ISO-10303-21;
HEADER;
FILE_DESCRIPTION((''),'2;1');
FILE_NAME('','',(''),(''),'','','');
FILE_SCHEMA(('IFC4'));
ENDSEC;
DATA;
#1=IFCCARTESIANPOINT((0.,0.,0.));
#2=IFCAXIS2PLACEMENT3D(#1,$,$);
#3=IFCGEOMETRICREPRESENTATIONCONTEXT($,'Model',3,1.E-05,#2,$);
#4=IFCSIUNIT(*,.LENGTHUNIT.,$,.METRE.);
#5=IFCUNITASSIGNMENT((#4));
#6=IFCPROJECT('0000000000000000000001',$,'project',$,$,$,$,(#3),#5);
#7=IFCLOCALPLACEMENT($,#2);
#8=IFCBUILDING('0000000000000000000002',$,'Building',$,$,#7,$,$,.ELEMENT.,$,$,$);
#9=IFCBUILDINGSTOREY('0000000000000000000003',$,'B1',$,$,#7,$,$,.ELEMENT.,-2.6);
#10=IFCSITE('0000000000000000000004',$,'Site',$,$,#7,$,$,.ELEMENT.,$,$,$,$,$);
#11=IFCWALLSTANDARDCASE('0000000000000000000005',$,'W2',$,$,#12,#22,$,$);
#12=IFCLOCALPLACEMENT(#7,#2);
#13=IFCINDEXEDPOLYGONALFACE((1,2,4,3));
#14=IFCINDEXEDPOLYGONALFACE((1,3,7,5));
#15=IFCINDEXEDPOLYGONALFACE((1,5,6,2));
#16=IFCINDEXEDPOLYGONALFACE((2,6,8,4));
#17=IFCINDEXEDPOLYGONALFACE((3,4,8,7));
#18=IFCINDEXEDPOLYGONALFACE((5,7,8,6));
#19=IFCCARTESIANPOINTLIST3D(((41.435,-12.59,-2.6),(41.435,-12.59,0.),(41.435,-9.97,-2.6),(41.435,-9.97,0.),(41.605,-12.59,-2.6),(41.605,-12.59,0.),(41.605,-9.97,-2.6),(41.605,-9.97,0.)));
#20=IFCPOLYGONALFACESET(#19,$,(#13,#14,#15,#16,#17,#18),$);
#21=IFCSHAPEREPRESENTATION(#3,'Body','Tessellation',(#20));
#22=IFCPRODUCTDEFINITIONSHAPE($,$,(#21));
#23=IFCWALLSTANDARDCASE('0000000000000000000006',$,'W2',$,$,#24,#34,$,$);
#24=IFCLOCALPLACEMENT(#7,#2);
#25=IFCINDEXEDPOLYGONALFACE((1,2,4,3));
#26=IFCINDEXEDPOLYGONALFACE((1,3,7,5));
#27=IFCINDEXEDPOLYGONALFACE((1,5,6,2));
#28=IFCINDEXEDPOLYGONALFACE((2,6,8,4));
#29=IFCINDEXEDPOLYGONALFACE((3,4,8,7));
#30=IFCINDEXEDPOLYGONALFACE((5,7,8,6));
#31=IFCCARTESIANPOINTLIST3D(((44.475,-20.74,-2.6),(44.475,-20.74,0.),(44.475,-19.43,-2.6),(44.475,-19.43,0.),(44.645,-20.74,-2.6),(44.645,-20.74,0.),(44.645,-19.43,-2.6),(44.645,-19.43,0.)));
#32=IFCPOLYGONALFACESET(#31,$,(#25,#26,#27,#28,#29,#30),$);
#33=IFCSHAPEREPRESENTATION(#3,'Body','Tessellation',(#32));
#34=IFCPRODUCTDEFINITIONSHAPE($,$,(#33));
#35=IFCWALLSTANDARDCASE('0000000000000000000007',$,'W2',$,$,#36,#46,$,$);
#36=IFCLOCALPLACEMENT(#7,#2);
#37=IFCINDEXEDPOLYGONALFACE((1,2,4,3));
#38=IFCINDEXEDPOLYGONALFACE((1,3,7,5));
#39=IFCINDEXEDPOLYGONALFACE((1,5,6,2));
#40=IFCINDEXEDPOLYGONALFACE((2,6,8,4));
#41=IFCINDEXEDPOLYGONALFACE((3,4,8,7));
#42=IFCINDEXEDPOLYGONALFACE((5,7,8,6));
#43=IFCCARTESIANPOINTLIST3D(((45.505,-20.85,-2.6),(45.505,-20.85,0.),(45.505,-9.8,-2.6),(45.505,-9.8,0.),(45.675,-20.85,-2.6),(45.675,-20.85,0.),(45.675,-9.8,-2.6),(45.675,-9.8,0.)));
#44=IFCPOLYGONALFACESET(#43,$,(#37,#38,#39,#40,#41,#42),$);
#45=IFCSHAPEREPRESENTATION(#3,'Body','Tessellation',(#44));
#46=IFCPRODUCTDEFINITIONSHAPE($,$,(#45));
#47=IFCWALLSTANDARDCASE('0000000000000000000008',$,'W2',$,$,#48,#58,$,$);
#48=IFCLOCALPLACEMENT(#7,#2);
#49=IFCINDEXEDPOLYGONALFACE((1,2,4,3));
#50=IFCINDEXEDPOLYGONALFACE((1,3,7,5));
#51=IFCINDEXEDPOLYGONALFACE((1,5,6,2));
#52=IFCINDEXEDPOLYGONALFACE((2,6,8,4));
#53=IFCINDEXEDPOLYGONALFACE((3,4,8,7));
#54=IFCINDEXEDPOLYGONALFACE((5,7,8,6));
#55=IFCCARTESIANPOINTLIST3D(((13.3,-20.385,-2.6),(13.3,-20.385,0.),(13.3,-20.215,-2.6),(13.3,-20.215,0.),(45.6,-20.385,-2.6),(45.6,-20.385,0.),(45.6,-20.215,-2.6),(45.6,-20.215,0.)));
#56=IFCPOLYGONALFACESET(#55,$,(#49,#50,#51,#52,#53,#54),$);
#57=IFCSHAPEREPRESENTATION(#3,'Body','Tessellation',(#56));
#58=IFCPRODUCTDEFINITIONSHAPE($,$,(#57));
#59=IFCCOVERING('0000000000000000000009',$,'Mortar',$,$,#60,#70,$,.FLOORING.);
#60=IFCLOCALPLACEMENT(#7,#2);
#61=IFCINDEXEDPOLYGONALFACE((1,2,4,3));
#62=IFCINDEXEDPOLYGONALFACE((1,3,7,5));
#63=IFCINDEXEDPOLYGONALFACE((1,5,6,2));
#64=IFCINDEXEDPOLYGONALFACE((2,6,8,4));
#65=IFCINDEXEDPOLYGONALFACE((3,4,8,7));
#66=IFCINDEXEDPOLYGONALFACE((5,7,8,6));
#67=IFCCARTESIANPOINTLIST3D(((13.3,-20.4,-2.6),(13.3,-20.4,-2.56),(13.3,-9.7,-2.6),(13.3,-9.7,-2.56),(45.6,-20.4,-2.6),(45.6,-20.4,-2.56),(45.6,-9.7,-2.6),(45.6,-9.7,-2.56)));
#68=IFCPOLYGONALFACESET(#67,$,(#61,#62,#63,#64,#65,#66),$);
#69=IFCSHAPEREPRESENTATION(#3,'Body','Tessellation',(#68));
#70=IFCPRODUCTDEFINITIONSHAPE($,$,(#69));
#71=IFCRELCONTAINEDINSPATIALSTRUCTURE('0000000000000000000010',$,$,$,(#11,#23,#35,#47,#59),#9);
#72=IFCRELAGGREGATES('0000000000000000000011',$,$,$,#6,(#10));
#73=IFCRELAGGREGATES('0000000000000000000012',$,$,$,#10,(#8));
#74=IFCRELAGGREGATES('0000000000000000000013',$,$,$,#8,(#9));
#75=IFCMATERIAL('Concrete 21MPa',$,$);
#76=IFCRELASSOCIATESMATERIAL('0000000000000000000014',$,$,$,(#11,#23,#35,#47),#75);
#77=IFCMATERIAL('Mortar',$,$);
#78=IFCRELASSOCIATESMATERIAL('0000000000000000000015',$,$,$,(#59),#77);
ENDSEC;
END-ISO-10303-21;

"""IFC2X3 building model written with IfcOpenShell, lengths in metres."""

from ifc_helpers import new_model, si_unit, frame, origin, origin_2d, place, context, project, spatial, rectangle, extrude, material, element, save


model = new_model("IFC2X3")

# Units and contexts
model_context = context("Model", 3, precision=1e-05, world=origin())
ifc_project = project(units=[si_unit("LENGTHUNIT", "METRE")], contexts=[model_context])

# Site, building, storey
placement = place(None, origin())
site = spatial("IfcSite", under=ifc_project, at=placement, Name="Site", CompositionType="ELEMENT")
building = spatial("IfcBuilding", under=site, at=placement, Name="Building", CompositionType="ELEMENT")
storey = spatial("IfcBuildingStorey", under=building, at=placement, Name="B1", CompositionType="ELEMENT", Elevation=-2.6)

# Shared definitions
ifc_material_1 = material(Name="Concrete 21MPa")

# Walls
wall_1_placement = place(None, frame((41.52, -11.28, -2.6)))
element("IfcWallStandardCase", 1, at=wall_1_placement, inside=storey, material=ifc_material_1, Name="W2", context=model_context, shape_type="SweptSolid", body=[
    extrude(rectangle(XDim=0.17, YDim=2.62, at=origin_2d()), origin(), (0.0, 0.0, 1.0), 2.6),
])
wall_2_placement = place(None, frame((44.56, -20.085, -2.6)))
element("IfcWallStandardCase", 2, at=wall_2_placement, inside=storey, material=ifc_material_1, Name="W2", context=model_context, shape_type="SweptSolid", body=[
    extrude(rectangle(XDim=0.17, YDim=1.31, at=origin_2d()), origin(), (0.0, 0.0, 1.0), 2.6),
])
wall_3_placement = place(None, frame((45.59, -15.325, -2.6)))
element("IfcWallStandardCase", 3, at=wall_3_placement, inside=storey, material=ifc_material_1, Name="W2", context=model_context, shape_type="SweptSolid", body=[
    extrude(rectangle(XDim=0.17, YDim=11.05, at=origin_2d()), origin(), (0.0, 0.0, 1.0), 2.6),
])
wall_4_placement = place(None, frame((29.45, -20.3, -2.6)))
element("IfcWallStandardCase", 4, at=wall_4_placement, inside=storey, material=ifc_material_1, Name="W2", context=model_context, shape_type="SweptSolid", body=[
    extrude(rectangle(XDim=32.3, YDim=0.17, at=origin_2d()), origin(), (0.0, 0.0, 1.0), 2.6),
])

# Covering
ifc_material_2 = material(Name="Mortar")
covering_placement = place(None, frame((29.45, -15.05, -2.6)))
element("IfcCovering", 5, at=covering_placement, inside=storey, material=ifc_material_2, Name="Mortar", PredefinedType="FLOORING", context=model_context, shape_type="SweptSolid", body=[
    extrude(rectangle(XDim=32.3, YDim=10.7, at=origin_2d()), origin(), (0.0, 0.0, 1.0), 0.04),
])

save(model, "model.ifc")
